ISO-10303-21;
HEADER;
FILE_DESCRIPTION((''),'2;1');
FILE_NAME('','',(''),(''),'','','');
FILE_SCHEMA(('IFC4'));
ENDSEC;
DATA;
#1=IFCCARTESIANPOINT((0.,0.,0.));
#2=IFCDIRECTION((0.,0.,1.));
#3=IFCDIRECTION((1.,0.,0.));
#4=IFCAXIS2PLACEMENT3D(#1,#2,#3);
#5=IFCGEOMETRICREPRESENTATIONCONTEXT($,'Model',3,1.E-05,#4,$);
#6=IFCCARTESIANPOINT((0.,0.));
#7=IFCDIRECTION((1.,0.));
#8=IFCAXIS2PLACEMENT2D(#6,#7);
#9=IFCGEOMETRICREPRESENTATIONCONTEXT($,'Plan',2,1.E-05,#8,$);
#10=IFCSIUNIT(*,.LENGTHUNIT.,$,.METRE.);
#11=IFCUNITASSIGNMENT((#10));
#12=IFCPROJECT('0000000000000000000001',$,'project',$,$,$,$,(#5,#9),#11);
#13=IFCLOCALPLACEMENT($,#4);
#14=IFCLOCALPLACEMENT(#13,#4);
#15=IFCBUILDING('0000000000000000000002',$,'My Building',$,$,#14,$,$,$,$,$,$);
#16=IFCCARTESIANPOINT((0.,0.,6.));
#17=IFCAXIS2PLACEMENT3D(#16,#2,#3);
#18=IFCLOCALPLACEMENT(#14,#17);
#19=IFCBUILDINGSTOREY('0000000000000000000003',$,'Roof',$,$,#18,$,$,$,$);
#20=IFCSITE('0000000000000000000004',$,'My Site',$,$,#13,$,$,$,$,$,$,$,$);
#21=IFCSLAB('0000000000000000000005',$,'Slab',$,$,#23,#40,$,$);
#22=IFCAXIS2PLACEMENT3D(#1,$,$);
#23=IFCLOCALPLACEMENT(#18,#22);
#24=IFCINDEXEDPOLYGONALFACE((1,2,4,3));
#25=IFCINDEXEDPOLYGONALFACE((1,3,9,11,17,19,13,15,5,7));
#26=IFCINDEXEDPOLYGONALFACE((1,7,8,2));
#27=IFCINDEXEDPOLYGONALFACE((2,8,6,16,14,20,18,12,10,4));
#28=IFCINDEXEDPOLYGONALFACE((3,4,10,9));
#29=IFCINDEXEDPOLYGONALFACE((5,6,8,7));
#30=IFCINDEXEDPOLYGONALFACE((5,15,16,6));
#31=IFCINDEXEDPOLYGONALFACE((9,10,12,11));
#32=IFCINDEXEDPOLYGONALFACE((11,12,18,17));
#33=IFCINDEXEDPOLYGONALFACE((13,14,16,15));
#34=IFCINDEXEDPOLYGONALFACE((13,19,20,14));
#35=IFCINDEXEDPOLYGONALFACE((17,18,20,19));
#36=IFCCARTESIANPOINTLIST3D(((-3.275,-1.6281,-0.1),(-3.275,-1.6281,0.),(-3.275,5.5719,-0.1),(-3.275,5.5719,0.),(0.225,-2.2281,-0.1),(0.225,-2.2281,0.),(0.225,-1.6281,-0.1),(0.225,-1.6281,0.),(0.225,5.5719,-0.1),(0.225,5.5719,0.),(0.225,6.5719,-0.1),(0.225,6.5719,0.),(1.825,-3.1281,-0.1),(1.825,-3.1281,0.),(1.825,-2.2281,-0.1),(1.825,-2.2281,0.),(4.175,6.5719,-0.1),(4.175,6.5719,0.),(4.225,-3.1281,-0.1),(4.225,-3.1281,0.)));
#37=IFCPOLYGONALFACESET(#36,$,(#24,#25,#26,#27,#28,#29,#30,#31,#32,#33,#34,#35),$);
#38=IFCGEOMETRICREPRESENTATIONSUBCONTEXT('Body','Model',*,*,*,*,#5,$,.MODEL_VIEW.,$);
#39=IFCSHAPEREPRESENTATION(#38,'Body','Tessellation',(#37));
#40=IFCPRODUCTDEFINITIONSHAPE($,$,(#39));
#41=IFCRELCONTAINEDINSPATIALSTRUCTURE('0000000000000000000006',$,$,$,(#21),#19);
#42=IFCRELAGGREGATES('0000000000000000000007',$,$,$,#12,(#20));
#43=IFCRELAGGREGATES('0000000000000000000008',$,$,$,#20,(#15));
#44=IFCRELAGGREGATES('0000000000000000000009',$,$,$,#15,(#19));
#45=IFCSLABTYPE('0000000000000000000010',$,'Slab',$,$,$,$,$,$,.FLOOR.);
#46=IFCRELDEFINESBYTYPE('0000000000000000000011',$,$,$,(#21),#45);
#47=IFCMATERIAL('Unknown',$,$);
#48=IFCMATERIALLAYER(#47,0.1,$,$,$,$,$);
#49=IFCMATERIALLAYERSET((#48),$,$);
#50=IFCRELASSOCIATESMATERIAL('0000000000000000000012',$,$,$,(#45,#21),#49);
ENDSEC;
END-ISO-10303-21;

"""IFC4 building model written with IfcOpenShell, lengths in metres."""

from ifc_helpers import new_model, si_unit, frame, origin_with_axes, origin_2d_with_axis, place, context, subcontext, project, spatial, indexed_curve, outline, extrude, material, layer, layer_set, layer_usage, type_object, element, save


model = new_model("IFC4")

# Units and contexts
model_context = context("Model", 3, precision=1e-05, world=origin_with_axes())
plan_context = context("Plan", 2, precision=1e-05, world=origin_2d_with_axis())
body_context = subcontext(model_context, "Body", "Model", "MODEL_VIEW")
ifc_project = project(units=[si_unit("LENGTHUNIT", "METRE")], contexts=[model_context, plan_context])

# Site, building, storey
site_placement = place(None, origin_with_axes())
site = spatial("IfcSite", under=ifc_project, at=site_placement, Name="My Site")
building_placement = place(site_placement, origin_with_axes())
building = spatial("IfcBuilding", under=site, at=building_placement, Name="My Building")
storey_placement = place(building_placement, frame((0.0, 0.0, 6.0), z_axis=(0.0, 0.0, 1.0), x_axis=(1.0, 0.0, 0.0)))
storey = spatial("IfcBuildingStorey", under=building, at=storey_placement, Name="Roof")

# Slab
ifc_material = material(Name="Unknown")
ifc_layer = layer(ifc_material, 0.1)
ifc_layer_set = layer_set([ifc_layer])
ifc_layer_usage = layer_usage(ifc_layer_set, "AXIS3", "POSITIVE", -0.1)
slab_type = type_object("IfcSlabType", Name="Slab", PredefinedType="FLOOR", material=ifc_layer_set)
slab_placement = place(storey_placement, frame((0.225, -2.2281, 0.0), z_axis=(0.0, 0.0, 1.0), x_axis=(1.0, 0.0, 0.0)))
element("IfcSlab", 1, at=slab_placement, inside=storey, type_object=slab_type, material=ifc_layer_usage, Name="Slab", context=body_context, shape_type="SweptSolid", body=[
    extrude(outline(indexed_curve([(0.0, 0.0), (1.6, 0.0), (1.6, -0.9), (4.0, -0.9), (3.95, 8.8), (0.0, 8.8), (0.0, 7.8), (-3.5, 7.8), (-3.5, 0.6), (0.0, 0.6), (0.0, 0.0)])), frame((0.0, 0.0, -0.1), z_axis=(0.0, 0.0, 1.0), x_axis=(1.0, 0.0, 0.0)), (0.0, 0.0, 1.0), 0.1),
])

save(model, "model.ifc")
